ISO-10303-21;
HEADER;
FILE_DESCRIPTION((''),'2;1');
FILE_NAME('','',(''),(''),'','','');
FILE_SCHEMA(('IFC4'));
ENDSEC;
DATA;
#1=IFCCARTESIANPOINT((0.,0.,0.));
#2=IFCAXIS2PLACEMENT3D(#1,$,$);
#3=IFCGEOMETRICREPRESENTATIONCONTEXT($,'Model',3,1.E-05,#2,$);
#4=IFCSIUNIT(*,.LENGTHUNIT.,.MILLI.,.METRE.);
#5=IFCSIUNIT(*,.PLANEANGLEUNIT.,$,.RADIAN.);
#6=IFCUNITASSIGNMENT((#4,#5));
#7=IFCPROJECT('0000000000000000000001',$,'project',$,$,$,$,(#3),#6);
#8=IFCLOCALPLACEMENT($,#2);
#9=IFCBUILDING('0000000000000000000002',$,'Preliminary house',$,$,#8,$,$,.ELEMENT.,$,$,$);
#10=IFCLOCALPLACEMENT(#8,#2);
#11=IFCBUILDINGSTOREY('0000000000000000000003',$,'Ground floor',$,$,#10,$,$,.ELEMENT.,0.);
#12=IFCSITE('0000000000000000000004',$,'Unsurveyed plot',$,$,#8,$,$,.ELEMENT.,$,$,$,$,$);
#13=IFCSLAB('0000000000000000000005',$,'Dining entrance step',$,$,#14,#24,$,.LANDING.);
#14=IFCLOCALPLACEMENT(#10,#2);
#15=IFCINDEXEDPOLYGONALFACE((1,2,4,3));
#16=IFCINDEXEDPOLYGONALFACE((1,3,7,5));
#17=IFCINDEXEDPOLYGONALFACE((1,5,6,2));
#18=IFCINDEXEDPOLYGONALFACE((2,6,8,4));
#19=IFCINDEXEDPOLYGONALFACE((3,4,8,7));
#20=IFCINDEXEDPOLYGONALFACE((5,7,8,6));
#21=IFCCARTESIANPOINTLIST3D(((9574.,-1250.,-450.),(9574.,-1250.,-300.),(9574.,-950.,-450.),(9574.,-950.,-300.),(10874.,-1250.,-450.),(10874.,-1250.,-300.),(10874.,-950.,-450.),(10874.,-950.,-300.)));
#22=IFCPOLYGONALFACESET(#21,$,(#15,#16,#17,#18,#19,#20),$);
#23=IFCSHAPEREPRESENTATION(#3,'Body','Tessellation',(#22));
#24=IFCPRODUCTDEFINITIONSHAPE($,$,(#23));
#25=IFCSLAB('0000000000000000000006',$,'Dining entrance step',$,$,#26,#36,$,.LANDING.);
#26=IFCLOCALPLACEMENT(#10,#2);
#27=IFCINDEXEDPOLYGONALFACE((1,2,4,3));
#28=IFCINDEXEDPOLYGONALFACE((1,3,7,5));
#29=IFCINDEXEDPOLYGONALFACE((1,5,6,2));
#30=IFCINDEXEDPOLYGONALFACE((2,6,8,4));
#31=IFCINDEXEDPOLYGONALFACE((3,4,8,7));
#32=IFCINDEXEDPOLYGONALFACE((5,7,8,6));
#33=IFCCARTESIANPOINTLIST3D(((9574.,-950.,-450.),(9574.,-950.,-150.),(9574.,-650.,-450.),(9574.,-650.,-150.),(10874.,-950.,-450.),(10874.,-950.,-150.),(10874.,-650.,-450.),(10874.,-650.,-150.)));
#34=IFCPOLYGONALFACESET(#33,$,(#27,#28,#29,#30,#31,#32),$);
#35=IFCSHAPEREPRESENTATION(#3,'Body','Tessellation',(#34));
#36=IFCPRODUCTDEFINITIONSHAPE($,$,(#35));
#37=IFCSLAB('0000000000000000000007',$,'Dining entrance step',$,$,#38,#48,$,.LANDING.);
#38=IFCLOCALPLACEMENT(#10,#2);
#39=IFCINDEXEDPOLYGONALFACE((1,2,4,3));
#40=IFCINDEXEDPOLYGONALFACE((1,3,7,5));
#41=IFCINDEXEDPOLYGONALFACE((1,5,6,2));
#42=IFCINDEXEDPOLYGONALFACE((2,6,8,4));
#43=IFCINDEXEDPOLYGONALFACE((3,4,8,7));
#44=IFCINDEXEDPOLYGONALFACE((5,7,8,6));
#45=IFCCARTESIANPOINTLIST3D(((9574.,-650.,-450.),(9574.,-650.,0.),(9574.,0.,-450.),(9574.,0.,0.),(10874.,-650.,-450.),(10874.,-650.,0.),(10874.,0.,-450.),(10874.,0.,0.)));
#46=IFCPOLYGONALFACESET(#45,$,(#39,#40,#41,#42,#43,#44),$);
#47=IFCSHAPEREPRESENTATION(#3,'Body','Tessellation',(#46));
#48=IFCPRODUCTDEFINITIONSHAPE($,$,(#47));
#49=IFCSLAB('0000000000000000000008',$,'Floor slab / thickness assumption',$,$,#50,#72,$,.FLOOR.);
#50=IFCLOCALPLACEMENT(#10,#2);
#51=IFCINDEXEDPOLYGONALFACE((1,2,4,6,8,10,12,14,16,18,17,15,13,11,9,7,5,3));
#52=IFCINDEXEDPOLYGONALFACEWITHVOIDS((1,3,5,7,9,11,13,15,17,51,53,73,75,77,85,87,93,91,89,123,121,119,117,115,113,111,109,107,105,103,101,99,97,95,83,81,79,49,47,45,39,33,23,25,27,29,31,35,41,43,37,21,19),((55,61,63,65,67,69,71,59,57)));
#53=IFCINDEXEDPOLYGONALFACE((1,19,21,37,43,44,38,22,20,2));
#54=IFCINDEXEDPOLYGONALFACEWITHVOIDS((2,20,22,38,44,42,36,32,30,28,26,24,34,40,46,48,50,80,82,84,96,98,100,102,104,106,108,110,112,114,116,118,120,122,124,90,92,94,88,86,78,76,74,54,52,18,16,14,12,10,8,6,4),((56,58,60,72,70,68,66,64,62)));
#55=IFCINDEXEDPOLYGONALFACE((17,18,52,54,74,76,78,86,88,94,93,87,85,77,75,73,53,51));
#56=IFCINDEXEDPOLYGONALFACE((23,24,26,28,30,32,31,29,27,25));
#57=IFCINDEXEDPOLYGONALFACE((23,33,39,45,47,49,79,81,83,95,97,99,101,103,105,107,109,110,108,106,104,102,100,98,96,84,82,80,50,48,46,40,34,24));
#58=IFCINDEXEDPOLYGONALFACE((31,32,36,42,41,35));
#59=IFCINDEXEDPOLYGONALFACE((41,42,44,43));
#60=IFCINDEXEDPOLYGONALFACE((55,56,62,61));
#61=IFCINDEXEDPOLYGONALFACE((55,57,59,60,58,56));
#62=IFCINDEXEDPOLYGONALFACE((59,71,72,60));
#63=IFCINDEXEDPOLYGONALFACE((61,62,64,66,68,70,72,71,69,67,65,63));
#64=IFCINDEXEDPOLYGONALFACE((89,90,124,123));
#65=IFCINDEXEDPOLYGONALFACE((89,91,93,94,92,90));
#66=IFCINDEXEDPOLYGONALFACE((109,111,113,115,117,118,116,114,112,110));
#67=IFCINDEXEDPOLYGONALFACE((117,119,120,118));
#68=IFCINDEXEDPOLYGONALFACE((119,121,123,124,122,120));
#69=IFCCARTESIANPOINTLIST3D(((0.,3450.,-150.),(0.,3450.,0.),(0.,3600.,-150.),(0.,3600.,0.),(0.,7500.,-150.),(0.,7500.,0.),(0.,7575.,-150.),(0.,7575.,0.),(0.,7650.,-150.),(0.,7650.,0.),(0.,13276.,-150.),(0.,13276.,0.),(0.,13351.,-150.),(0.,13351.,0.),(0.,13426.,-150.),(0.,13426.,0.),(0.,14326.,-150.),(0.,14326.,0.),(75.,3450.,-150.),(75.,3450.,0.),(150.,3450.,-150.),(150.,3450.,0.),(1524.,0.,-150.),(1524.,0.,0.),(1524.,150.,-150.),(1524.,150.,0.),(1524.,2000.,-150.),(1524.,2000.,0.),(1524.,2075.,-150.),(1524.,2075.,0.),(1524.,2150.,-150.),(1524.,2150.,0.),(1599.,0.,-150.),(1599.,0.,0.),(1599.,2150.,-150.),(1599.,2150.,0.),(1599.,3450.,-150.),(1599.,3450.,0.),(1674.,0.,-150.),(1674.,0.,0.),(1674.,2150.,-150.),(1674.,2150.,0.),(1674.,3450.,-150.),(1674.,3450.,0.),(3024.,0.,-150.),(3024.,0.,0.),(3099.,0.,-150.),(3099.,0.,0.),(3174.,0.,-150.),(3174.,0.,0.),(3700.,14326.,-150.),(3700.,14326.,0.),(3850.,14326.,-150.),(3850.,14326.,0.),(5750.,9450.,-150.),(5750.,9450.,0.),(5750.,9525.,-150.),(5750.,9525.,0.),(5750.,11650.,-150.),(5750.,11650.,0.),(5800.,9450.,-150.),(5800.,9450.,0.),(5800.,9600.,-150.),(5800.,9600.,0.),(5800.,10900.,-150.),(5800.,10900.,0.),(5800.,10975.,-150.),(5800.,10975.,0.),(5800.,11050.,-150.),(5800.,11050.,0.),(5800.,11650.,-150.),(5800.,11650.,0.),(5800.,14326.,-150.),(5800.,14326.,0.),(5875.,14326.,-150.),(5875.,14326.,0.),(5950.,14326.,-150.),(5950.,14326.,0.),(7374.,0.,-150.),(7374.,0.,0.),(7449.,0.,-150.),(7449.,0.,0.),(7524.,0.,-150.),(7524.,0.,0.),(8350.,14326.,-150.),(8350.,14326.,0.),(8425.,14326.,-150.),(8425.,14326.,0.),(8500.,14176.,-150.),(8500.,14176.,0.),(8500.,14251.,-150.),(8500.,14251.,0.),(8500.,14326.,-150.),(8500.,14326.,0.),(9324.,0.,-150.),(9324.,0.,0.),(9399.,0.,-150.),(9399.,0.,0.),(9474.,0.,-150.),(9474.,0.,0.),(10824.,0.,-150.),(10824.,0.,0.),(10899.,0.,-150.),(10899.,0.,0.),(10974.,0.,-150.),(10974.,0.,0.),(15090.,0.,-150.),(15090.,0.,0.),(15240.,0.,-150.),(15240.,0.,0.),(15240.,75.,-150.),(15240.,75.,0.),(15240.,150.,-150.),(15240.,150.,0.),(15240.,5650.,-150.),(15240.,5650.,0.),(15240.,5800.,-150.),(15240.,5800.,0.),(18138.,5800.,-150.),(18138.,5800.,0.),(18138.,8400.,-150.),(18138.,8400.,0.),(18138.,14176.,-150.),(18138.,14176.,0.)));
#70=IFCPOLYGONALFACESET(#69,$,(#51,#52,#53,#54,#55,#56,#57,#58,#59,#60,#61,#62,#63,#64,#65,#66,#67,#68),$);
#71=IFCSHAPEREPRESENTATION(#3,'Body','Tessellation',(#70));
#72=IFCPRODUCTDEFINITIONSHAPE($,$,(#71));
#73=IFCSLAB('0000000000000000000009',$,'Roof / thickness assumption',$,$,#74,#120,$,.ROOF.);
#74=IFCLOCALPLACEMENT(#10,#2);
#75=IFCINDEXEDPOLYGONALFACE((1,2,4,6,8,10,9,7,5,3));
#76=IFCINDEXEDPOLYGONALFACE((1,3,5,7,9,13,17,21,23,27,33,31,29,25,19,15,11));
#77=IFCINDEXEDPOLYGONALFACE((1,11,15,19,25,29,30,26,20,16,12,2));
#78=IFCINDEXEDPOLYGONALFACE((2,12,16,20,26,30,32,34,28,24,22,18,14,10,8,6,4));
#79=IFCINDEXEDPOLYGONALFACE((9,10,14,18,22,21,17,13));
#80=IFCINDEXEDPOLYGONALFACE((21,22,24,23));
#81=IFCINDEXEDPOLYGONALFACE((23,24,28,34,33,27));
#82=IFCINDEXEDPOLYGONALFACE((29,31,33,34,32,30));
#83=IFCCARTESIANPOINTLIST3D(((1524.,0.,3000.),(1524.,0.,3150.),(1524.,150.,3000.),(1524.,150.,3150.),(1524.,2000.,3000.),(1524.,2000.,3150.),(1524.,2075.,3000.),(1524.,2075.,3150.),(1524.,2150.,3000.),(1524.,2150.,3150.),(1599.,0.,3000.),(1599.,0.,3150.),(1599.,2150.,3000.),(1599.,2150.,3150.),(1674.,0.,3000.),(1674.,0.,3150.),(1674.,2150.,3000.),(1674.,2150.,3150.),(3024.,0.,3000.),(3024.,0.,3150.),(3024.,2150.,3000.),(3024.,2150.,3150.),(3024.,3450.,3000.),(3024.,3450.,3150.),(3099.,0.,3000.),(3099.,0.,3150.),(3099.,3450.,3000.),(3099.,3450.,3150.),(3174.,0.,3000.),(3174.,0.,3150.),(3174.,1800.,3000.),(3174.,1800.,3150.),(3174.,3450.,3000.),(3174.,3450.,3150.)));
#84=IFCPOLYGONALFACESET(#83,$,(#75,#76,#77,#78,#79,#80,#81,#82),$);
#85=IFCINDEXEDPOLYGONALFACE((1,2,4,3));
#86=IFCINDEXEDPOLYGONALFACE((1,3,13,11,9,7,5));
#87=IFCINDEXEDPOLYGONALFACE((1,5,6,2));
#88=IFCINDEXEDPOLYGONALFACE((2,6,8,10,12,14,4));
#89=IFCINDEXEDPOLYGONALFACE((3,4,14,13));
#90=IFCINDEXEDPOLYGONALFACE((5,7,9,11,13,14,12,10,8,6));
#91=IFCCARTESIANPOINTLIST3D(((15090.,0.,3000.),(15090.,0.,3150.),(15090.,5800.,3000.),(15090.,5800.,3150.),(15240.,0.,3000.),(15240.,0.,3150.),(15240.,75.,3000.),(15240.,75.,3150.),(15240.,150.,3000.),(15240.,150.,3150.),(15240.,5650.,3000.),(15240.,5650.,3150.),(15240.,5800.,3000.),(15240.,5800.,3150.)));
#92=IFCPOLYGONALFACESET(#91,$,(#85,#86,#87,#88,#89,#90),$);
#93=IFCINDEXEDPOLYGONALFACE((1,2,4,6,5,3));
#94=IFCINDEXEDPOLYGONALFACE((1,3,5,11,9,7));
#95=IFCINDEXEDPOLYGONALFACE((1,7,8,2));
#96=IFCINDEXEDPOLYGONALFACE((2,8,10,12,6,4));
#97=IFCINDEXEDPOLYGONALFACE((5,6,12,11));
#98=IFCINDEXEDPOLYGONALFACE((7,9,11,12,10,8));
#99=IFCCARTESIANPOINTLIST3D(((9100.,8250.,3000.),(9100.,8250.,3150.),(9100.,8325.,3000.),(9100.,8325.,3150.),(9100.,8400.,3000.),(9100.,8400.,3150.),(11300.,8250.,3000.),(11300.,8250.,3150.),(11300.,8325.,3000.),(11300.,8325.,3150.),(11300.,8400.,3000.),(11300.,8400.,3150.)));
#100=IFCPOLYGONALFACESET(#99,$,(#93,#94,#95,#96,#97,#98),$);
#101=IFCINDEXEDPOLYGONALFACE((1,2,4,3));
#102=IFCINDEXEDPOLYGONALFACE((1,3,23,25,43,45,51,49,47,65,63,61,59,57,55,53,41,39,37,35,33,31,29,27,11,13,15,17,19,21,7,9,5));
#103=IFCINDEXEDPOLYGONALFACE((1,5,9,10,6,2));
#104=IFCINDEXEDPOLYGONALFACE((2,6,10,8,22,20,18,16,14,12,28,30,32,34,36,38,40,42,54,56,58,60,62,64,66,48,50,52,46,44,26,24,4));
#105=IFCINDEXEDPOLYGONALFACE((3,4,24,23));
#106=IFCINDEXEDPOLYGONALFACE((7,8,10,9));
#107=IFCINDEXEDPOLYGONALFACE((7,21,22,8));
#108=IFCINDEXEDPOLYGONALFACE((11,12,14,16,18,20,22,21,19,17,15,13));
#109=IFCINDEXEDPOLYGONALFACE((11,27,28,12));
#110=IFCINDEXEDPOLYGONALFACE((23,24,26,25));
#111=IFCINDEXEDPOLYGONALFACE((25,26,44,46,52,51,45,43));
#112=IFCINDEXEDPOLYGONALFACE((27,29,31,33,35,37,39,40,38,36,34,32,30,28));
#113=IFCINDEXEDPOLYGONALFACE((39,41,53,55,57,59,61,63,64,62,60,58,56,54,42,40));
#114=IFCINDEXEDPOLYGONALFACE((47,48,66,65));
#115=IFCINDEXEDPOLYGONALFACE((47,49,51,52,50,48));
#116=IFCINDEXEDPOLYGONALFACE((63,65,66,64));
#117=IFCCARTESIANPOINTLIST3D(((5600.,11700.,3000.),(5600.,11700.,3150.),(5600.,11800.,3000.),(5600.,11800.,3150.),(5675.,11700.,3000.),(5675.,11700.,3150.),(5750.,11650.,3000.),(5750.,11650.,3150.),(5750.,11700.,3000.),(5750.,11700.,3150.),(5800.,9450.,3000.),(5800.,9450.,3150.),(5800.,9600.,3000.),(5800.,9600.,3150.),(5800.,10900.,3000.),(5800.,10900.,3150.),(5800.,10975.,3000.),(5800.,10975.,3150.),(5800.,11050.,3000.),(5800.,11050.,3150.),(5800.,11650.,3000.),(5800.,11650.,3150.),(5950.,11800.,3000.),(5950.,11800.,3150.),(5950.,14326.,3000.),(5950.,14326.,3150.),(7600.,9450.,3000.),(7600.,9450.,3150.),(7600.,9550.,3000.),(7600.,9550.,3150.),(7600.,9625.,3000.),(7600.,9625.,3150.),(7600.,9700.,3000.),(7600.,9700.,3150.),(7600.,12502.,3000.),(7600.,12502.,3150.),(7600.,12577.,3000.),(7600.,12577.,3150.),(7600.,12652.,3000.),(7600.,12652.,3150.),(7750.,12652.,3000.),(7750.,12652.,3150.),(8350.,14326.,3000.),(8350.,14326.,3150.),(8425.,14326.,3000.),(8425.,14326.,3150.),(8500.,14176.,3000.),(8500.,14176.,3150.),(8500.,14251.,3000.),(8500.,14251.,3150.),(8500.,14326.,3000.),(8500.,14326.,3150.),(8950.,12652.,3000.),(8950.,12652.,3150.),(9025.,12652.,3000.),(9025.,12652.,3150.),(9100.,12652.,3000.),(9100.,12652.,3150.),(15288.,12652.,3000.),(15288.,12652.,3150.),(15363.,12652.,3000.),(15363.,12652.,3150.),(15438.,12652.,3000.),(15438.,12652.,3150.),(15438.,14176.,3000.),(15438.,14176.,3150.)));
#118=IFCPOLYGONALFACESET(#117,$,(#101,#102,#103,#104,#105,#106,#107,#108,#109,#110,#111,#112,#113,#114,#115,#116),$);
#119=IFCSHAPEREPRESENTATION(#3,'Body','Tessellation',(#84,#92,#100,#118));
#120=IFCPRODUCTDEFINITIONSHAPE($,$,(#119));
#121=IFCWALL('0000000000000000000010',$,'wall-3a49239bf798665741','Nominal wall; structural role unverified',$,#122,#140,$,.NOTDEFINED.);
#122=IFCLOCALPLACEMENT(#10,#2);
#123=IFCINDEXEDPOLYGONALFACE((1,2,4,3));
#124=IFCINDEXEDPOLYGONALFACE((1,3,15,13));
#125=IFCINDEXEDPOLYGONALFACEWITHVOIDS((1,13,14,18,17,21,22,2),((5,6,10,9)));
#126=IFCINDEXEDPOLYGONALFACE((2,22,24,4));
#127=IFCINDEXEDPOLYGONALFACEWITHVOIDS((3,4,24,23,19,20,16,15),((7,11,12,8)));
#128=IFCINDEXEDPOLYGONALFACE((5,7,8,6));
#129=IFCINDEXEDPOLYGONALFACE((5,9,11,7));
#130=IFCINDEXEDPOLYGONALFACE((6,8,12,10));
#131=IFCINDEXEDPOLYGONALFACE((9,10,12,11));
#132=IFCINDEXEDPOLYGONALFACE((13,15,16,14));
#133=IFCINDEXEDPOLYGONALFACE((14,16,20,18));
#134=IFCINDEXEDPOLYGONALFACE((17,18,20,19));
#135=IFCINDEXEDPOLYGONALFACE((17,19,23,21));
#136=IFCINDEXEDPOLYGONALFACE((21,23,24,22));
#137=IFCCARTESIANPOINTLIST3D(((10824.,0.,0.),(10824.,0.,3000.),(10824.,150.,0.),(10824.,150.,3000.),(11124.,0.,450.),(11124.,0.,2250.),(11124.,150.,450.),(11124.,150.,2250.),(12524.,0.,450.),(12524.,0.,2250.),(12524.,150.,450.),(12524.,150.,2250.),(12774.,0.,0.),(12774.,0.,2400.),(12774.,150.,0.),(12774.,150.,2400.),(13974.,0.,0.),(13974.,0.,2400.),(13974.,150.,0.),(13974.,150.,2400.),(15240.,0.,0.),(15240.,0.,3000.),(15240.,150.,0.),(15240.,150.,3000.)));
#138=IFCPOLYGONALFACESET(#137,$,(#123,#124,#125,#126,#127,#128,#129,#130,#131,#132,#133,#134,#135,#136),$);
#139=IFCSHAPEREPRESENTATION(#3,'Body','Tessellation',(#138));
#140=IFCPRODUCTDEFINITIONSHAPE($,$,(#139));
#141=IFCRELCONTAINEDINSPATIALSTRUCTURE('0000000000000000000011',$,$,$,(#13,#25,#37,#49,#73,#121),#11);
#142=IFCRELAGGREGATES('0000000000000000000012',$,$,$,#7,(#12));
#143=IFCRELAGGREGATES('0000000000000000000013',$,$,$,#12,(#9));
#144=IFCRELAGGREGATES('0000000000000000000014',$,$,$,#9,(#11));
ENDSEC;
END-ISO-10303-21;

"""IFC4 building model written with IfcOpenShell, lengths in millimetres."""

from ifc_helpers import new_model, si_unit, frame, origin, place, context, project, spatial, polyline, outline, extrude, element, save


model = new_model("IFC4")

# Units and contexts
model_context = context("Model", 3, precision=1e-05, world=origin())
ifc_project = project(units=[si_unit("LENGTHUNIT", "METRE", prefix="MILLI"), si_unit("PLANEANGLEUNIT", "RADIAN")], contexts=[model_context])

# Site, building, storey
placement_1 = place(None, origin())
site = spatial("IfcSite", under=ifc_project, at=placement_1, Name="Unsurveyed plot", CompositionType="ELEMENT")
building = spatial("IfcBuilding", under=site, at=placement_1, Name="Preliminary house", CompositionType="ELEMENT")
placement_2 = place(placement_1, origin())
storey = spatial("IfcBuildingStorey", under=building, at=placement_2, Name="Ground floor", CompositionType="ELEMENT", Elevation=0.0)

# Slabs
element("IfcSlab", 1, at=placement_2, inside=storey, Name="Dining entrance step", PredefinedType="LANDING", context=model_context, shape_type="SweptSolid", body=[
    extrude(outline(polyline([(9574.0, -1250.0), (10874.0, -1250.0), (10874.0, -950.0), (9574.0, -950.0), (9574.0, -1250.0)])), frame((0.0, 0.0, -450.0)), (0.0, 0.0, 1.0), 150.0),
])
element("IfcSlab", 2, at=placement_2, inside=storey, Name="Dining entrance step", PredefinedType="LANDING", context=model_context, shape_type="SweptSolid", body=[
    extrude(outline(polyline([(9574.0, -950.0), (10874.0, -950.0), (10874.0, -650.0), (9574.0, -650.0), (9574.0, -950.0)])), frame((0.0, 0.0, -450.0)), (0.0, 0.0, 1.0), 300.0),
])
element("IfcSlab", 3, at=placement_2, inside=storey, Name="Dining entrance step", PredefinedType="LANDING", context=model_context, shape_type="SweptSolid", body=[
    extrude(outline(polyline([(9574.0, -650.0), (10874.0, -650.0), (10874.0, 0.0), (9574.0, 0.0), (9574.0, -650.0)])), frame((0.0, 0.0, -450.0)), (0.0, 0.0, 1.0), 450.0),
])
element("IfcSlab", 4, at=placement_2, inside=storey, Name="Floor slab / thickness assumption", PredefinedType="FLOOR", context=model_context, shape_type="SweptSolid", body=[
    extrude(outline(polyline([(1524.0, 0.0), (1524.0, 150.0), (1524.0, 2000.0), (1524.0, 2075.0), (1524.0, 2150.0), (1599.0, 2150.0), (1674.0, 2150.0), (1674.0, 3450.0), (1599.0, 3450.0), (150.0, 3450.0), (75.0, 3450.0), (0.0, 3450.0), (0.0, 3600.0), (0.0, 7500.0), (0.0, 7575.0), (0.0, 7650.0), (0.0, 13276.0), (0.0, 13351.0), (0.0, 13426.0), (0.0, 14326.0), (3700.0, 14326.0), (3850.0, 14326.0), (5800.0, 14326.0), (5875.0, 14326.0), (5950.0, 14326.0), (8350.0, 14326.0), (8425.0, 14326.0), (8500.0, 14326.0), (8500.0, 14251.0), (8500.0, 14176.0), (18138.0, 14176.0), (18138.0, 8400.0), (18138.0, 5800.0), (15240.0, 5800.0), (15240.0, 5650.0), (15240.0, 150.0), (15240.0, 75.0), (15240.0, 0.0), (15090.0, 0.0), (10974.0, 0.0), (10899.0, 0.0), (10824.0, 0.0), (9474.0, 0.0), (9399.0, 0.0), (9324.0, 0.0), (7524.0, 0.0), (7449.0, 0.0), (7374.0, 0.0), (3174.0, 0.0), (3099.0, 0.0), (3024.0, 0.0), (1674.0, 0.0), (1599.0, 0.0), (1524.0, 0.0)]), holes=[polyline([(5800.0, 9600.0), (5800.0, 10900.0), (5800.0, 10975.0), (5800.0, 11050.0), (5800.0, 11650.0), (5750.0, 11650.0), (5750.0, 9525.0), (5750.0, 9450.0), (5800.0, 9450.0), (5800.0, 9600.0)])]), frame((0.0, 0.0, -150.0)), (0.0, 0.0, 1.0), 150.0),
])
element("IfcSlab", 5, at=placement_2, inside=storey, Name="Roof / thickness assumption", PredefinedType="ROOF", context=model_context, shape_type="SweptSolid", body=[
    extrude(outline(polyline([(3024.0, 3450.0), (3099.0, 3450.0), (3174.0, 3450.0), (3174.0, 1800.0), (3174.0, 0.0), (3099.0, 0.0), (3024.0, 0.0), (1674.0, 0.0), (1599.0, 0.0), (1524.0, 0.0), (1524.0, 150.0), (1524.0, 2000.0), (1524.0, 2075.0), (1524.0, 2150.0), (1599.0, 2150.0), (1674.0, 2150.0), (3024.0, 2150.0), (3024.0, 3450.0)])), frame((0.0, 0.0, 3000.0)), (0.0, 0.0, 1.0), 150.0),
    extrude(outline(polyline([(15240.0, 75.0), (15240.0, 0.0), (15090.0, 0.0), (15090.0, 5800.0), (15240.0, 5800.0), (15240.0, 5650.0), (15240.0, 150.0), (15240.0, 75.0)])), frame((0.0, 0.0, 3000.0)), (0.0, 0.0, 1.0), 150.0),
    extrude(outline(polyline([(9100.0, 8400.0), (11300.0, 8400.0), (11300.0, 8325.0), (11300.0, 8250.0), (9100.0, 8250.0), (9100.0, 8325.0), (9100.0, 8400.0)])), frame((0.0, 0.0, 3000.0)), (0.0, 0.0, 1.0), 150.0),
    extrude(outline(polyline([(8500.0, 14326.0), (8500.0, 14251.0), (8500.0, 14176.0), (15438.0, 14176.0), (15438.0, 12652.0), (15363.0, 12652.0), (15288.0, 12652.0), (9100.0, 12652.0), (9025.0, 12652.0), (8950.0, 12652.0), (7750.0, 12652.0), (7600.0, 12652.0), (7600.0, 12577.0), (7600.0, 12502.0), (7600.0, 9700.0), (7600.0, 9625.0), (7600.0, 9550.0), (7600.0, 9450.0), (5800.0, 9450.0), (5800.0, 9600.0), (5800.0, 10900.0), (5800.0, 10975.0), (5800.0, 11050.0), (5800.0, 11650.0), (5750.0, 11650.0), (5750.0, 11700.0), (5675.0, 11700.0), (5600.0, 11700.0), (5600.0, 11800.0), (5950.0, 11800.0), (5950.0, 14326.0), (8350.0, 14326.0), (8425.0, 14326.0), (8500.0, 14326.0)])), frame((0.0, 0.0, 3000.0)), (0.0, 0.0, 1.0), 150.0),
])

# Wall, openings
wall_1 = element("IfcWall", 6, at=placement_2, inside=storey, Name="wall-3a49239bf798665741", Description="Nominal wall; structural role unverified", PredefinedType="NOTDEFINED", context=model_context, shape_type="SweptSolid", body=[
    extrude(outline(polyline([(15165.0, 150.0), (15240.0, 150.0), (15240.0, 0.0), (10899.0, 0.0), (10824.0, 0.0), (10824.0, 150.0), (15165.0, 150.0)])), origin(), (0.0, 0.0, 1.0), 3000.0),
])
element("IfcOpeningElement", 7, at=placement_2, cuts=wall_1, PredefinedType="OPENING", context=model_context, shape_type="SweptSolid", body=[
    extrude(outline(polyline([(11124.0, -375.0), (12524.0, -375.0), (12524.0, 525.0), (11124.0, 525.0), (11124.0, -375.0)])), frame((0.0, 0.0, 450.0)), (0.0, 0.0, 1.0), 1800.0),
])
element("IfcOpeningElement", 8, at=placement_2, cuts=wall_1, PredefinedType="OPENING", context=model_context, shape_type="SweptSolid", body=[
    extrude(outline(polyline([(12774.0, -375.0), (13974.0, -375.0), (13974.0, 525.0), (12774.0, 525.0), (12774.0, -375.0)])), origin(), (0.0, 0.0, 1.0), 2400.0),
])

save(model, "model.ifc")
